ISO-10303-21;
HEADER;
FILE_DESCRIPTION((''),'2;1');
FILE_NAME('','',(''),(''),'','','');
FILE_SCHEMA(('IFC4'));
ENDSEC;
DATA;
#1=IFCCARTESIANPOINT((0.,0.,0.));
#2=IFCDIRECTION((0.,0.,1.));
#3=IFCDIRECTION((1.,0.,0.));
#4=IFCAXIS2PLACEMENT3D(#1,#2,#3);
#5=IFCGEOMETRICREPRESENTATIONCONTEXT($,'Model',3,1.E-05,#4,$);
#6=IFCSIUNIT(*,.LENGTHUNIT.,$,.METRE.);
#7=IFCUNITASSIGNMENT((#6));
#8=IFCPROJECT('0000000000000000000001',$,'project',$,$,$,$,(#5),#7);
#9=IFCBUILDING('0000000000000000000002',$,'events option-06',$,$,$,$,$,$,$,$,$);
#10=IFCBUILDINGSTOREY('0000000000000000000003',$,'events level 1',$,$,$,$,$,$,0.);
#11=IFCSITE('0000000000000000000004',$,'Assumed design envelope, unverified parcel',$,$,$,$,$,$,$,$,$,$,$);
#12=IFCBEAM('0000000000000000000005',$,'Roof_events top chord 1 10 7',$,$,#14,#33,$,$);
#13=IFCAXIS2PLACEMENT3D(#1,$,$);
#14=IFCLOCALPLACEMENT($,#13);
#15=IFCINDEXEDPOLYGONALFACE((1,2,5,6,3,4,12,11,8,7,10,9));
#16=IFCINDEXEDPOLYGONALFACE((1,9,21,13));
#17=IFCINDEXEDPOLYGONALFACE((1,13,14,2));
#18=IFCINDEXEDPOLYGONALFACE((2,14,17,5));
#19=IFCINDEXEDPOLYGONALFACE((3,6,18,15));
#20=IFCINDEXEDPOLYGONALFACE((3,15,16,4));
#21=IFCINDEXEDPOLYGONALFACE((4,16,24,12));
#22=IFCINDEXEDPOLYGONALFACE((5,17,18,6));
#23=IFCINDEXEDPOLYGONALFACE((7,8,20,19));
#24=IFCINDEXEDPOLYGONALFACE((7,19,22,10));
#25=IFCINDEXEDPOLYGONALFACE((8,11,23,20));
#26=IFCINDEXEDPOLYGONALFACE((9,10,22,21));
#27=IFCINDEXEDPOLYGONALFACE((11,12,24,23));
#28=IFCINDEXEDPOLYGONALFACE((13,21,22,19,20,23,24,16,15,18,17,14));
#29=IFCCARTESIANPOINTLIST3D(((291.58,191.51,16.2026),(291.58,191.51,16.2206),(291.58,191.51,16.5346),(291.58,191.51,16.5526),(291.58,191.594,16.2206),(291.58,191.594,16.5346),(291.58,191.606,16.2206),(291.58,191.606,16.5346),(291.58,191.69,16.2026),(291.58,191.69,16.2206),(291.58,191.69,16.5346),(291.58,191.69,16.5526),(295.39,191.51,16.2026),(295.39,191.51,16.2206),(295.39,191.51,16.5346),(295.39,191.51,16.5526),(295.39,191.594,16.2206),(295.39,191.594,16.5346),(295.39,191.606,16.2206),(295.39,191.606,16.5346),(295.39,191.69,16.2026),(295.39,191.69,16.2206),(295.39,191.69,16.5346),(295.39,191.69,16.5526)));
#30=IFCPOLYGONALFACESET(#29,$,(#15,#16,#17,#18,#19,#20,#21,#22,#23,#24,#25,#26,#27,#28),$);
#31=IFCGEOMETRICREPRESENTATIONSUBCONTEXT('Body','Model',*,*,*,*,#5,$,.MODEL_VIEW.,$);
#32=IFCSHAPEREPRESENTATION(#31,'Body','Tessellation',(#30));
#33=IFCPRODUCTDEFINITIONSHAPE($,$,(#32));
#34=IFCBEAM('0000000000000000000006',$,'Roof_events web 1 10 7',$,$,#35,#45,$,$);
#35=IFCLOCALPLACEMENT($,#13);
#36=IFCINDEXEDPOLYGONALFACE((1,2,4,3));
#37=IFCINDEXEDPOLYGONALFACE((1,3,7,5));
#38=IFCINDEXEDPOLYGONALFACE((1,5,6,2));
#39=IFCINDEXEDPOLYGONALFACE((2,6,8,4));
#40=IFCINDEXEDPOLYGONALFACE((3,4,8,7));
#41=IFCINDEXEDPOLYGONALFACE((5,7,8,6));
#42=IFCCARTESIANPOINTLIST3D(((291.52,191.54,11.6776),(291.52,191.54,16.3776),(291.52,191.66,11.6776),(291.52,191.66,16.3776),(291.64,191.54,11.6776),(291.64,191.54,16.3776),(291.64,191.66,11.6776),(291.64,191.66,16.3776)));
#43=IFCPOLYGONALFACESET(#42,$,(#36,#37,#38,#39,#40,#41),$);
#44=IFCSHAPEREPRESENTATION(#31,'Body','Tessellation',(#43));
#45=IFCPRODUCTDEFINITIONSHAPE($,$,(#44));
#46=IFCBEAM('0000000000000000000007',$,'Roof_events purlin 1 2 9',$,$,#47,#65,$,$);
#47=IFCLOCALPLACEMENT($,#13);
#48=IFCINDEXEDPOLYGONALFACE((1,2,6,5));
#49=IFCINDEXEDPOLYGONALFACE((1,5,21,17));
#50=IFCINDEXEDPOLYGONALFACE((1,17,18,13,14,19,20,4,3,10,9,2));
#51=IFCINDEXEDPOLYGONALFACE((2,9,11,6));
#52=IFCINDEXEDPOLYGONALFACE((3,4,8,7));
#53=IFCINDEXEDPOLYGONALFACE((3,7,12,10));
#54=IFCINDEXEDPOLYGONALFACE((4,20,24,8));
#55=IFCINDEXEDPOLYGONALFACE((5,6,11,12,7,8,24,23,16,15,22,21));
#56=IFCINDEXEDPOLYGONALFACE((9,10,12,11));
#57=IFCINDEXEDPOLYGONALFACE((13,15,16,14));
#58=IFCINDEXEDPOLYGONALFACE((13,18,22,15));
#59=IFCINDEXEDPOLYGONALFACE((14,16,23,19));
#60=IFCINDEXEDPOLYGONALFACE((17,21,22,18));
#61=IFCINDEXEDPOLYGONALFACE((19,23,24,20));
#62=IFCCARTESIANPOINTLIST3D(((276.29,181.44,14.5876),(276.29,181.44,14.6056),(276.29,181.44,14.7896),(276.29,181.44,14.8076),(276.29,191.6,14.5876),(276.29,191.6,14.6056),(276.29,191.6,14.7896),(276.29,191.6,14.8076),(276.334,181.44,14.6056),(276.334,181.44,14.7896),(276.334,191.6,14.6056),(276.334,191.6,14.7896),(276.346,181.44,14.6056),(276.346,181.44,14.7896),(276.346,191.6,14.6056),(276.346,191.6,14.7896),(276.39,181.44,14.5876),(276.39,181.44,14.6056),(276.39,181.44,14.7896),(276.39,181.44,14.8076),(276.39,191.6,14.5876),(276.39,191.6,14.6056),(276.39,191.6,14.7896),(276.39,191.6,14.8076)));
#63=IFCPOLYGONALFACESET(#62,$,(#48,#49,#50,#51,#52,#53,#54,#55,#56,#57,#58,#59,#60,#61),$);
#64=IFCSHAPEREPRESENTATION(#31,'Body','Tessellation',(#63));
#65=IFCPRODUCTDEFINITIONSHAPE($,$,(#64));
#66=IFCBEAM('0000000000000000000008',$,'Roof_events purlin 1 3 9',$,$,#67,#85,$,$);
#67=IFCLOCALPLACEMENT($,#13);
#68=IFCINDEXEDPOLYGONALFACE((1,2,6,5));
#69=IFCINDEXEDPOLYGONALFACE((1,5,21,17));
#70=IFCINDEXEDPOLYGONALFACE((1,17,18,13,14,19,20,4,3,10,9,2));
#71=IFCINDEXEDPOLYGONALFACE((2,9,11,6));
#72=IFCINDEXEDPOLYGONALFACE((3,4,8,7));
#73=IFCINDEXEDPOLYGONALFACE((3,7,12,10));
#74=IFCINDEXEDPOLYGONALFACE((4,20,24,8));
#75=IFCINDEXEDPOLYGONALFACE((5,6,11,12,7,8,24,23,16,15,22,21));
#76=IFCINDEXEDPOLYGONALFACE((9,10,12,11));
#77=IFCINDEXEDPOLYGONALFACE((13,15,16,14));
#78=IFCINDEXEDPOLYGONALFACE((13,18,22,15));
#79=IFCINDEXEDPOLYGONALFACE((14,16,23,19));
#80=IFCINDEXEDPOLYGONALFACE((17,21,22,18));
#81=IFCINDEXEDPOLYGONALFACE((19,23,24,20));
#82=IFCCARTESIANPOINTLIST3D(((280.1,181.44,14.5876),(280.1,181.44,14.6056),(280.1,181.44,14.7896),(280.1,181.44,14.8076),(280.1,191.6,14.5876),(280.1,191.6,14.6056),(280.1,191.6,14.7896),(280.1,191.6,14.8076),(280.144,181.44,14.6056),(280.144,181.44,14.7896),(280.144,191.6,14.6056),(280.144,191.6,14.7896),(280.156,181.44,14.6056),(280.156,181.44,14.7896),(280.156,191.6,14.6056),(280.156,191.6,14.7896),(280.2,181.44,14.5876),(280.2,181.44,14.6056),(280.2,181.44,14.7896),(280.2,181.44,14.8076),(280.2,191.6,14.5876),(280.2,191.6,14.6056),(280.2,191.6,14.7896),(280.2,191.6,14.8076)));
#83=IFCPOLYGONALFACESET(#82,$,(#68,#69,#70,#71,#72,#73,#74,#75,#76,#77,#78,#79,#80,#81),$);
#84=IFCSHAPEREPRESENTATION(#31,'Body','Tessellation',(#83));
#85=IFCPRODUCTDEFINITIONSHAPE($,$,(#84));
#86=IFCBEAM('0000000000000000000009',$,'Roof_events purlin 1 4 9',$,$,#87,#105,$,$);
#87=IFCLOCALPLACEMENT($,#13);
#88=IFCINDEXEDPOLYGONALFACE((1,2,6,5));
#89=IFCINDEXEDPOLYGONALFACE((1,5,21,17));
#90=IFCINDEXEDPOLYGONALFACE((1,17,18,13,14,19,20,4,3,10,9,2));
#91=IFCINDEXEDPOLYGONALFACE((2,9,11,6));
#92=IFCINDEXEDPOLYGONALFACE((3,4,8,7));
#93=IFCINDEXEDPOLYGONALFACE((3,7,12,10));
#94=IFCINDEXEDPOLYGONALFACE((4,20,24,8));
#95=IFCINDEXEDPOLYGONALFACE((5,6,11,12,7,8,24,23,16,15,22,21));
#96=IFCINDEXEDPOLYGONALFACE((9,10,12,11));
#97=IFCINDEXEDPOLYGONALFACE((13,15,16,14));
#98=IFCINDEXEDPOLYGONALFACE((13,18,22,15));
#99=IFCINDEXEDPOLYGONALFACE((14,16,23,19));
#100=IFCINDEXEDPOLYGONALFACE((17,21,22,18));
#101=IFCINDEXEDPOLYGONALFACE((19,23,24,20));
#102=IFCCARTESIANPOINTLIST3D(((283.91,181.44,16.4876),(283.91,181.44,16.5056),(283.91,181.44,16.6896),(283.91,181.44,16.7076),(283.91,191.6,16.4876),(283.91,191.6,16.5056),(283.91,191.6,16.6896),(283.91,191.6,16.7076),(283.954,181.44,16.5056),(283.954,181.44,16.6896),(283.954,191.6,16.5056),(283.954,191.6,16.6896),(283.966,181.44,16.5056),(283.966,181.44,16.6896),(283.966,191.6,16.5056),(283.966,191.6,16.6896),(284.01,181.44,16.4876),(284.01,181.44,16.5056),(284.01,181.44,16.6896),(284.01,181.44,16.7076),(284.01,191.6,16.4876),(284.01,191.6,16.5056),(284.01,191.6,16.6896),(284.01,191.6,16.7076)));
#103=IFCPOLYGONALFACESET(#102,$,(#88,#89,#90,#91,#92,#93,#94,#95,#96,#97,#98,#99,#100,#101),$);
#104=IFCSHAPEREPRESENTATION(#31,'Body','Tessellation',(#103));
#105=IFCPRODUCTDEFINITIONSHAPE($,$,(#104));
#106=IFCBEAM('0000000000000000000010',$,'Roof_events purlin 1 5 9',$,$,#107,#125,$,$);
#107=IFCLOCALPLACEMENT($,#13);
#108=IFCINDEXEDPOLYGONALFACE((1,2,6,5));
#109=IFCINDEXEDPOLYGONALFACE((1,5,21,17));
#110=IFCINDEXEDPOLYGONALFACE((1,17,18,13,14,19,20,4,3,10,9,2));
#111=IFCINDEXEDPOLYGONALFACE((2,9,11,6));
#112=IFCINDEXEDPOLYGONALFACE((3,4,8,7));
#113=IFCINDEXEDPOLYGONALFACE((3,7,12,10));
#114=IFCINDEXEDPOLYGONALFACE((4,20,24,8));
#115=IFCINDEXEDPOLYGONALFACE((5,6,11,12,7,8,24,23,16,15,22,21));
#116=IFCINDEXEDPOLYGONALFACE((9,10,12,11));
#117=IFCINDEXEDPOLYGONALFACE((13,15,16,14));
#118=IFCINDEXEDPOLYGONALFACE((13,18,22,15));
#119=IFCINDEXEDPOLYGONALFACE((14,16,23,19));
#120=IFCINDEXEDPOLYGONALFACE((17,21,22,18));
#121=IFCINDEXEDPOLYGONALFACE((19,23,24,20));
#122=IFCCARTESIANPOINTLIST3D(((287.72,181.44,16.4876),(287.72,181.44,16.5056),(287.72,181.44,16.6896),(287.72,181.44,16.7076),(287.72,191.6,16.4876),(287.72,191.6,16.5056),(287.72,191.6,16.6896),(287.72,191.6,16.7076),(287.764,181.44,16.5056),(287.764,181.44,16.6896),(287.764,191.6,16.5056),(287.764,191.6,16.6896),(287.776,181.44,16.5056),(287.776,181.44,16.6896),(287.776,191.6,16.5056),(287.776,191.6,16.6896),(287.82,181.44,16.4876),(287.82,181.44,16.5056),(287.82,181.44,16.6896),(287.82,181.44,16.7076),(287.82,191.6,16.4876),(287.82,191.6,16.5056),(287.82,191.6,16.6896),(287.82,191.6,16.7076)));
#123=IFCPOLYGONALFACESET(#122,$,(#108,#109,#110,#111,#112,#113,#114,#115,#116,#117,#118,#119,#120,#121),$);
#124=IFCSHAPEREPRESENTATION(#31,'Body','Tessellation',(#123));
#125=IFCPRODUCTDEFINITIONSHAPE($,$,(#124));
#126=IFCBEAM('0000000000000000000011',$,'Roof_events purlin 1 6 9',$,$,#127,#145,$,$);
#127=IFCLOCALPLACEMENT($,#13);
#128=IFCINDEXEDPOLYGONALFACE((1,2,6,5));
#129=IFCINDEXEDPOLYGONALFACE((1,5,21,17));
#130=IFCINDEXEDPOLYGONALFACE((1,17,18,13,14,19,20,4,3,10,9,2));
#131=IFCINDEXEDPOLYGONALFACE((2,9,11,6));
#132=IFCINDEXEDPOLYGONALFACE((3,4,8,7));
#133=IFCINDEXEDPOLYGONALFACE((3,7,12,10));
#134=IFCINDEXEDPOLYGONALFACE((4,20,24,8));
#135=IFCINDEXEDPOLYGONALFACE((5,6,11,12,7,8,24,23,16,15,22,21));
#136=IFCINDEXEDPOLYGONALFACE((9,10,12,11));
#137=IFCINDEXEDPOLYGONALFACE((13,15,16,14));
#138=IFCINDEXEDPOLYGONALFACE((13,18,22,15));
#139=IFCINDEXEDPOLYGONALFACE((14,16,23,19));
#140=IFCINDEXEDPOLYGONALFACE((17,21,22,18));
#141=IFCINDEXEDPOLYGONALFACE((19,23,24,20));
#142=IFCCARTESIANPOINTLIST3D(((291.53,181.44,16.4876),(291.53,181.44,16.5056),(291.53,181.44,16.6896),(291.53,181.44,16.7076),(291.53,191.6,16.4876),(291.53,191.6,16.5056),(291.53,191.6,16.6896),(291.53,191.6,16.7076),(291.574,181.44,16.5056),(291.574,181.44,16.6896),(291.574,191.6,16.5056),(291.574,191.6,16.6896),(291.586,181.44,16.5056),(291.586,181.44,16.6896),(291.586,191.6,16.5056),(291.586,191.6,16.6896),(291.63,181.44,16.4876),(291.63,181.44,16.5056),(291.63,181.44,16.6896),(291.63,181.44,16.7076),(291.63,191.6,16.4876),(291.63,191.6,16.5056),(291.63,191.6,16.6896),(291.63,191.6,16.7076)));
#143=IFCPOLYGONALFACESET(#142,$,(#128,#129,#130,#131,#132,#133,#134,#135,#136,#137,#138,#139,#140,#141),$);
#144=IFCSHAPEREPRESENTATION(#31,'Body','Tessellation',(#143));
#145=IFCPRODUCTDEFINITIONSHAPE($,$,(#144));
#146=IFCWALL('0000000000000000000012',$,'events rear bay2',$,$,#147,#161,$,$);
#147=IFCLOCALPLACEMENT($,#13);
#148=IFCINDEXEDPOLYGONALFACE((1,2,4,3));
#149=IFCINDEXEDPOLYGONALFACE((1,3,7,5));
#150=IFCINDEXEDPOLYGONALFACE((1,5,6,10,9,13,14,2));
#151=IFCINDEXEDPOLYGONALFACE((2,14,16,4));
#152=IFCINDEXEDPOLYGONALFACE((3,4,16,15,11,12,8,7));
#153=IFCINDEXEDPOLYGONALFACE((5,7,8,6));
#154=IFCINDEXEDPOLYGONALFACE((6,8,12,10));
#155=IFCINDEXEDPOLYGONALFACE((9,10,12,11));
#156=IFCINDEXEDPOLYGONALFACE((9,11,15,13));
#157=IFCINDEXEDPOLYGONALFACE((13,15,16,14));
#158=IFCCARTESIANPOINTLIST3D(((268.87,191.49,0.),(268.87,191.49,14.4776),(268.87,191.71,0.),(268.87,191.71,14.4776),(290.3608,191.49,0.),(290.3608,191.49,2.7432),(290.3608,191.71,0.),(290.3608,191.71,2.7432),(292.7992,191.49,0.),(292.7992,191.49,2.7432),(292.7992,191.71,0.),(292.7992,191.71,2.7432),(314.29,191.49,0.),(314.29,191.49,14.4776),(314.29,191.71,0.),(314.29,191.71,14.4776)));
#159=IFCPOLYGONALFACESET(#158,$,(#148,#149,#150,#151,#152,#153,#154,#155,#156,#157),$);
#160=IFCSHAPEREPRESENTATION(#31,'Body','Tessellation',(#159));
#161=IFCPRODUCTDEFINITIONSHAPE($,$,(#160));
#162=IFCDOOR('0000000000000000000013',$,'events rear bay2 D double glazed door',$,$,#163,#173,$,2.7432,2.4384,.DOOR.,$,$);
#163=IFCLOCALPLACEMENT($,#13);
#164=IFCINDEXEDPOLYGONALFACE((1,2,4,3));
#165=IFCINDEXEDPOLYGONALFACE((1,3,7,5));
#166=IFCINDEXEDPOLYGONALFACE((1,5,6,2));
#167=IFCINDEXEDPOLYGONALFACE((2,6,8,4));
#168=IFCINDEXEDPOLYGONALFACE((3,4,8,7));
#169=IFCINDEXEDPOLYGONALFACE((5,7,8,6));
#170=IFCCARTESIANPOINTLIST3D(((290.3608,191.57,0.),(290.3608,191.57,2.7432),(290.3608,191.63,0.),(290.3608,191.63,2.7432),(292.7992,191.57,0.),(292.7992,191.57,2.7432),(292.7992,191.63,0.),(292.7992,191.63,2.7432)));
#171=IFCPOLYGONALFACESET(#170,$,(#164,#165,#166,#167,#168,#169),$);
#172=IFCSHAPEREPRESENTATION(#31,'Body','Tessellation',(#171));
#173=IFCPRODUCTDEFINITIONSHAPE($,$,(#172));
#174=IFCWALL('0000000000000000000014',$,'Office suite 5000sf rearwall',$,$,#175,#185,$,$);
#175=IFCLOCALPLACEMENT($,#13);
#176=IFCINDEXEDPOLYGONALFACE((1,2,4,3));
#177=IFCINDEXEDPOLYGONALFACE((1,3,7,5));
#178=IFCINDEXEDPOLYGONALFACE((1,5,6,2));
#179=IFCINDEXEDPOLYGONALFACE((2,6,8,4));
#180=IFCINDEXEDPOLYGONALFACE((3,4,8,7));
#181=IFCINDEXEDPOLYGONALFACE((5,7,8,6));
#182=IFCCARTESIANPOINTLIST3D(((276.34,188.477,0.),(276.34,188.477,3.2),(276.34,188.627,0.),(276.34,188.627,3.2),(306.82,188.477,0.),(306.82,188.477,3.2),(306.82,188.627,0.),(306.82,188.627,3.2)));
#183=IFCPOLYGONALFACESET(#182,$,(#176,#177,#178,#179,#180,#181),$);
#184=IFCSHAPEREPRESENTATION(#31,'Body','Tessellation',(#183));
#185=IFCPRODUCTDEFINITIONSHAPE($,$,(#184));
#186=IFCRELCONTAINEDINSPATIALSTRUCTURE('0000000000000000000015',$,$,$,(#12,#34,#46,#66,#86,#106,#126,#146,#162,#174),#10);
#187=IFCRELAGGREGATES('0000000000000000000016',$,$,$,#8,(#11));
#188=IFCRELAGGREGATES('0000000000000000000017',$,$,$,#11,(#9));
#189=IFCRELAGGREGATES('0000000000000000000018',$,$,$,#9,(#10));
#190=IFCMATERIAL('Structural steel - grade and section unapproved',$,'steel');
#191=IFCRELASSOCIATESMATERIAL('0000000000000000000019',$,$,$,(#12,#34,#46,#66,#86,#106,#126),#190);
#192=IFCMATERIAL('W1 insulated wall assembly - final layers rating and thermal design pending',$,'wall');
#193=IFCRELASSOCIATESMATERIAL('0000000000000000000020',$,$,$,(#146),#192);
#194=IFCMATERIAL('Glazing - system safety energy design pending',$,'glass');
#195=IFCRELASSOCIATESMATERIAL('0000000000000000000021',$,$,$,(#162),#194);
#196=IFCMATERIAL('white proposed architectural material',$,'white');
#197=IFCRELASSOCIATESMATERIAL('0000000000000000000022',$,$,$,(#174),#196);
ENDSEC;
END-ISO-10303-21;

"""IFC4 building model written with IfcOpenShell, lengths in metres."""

from ifc_helpers import new_model, si_unit, frame, origin_with_axes, place, context, subcontext, project, spatial, rectangle, i_section, extrude, material, element, fill, save


model = new_model("IFC4")

# Units and contexts
model_context = context("Model", 3, precision=1e-05, world=origin_with_axes())
body_context = subcontext(model_context, "Body", "Model", "MODEL_VIEW")
ifc_project = project(units=[si_unit("LENGTHUNIT", "METRE")], contexts=[model_context])

# Site, building, storey
site = spatial("IfcSite", under=ifc_project, Name="Assumed design envelope, unverified parcel")
building = spatial("IfcBuilding", under=site, Name="events option-06")
storey = spatial("IfcBuildingStorey", under=building, Name="events level 1", Elevation=0.0)

# Beams
ifc_material_1 = material(Name="Structural steel - grade and section unapproved", Category="steel")
beam_1_placement = place(None, frame((291.58, 191.6, 16.3776), z_axis=(1.0, 0.0, 0.0), x_axis=(0.0, 1.0, 0.0)))
element("IfcBeam", 1, at=beam_1_placement, inside=storey, material=ifc_material_1, Name="Roof_events top chord 1 10 7", context=body_context, shape_type="SweptSolid", body=[
    extrude(i_section(OverallWidth=0.18, OverallDepth=0.35, WebThickness=0.012, FlangeThickness=0.018, FilletRadius=0.0), origin_with_axes(), (0.0, 0.0, 1.0), 3.81),
])
beam_2_placement = place(None, frame((291.58, 191.6, 11.6776), z_axis=(0.0, 0.0, 1.0), x_axis=(-1.0, 0.0, 0.0)))
element("IfcBeam", 2, at=beam_2_placement, inside=storey, material=ifc_material_1, Name="Roof_events web 1 10 7", context=body_context, shape_type="SweptSolid", body=[
    extrude(rectangle(XDim=0.12, YDim=0.12), origin_with_axes(), (0.0, 0.0, 1.0), 4.7),
])
for number, where, z_axis, x_axis, name in (
    (3, (276.34, 181.44, 14.6976), (0.0, 1.0, 0.0), (-1.0, 0.0, 0.0), "Roof_events purlin 1 2 9"),
    (4, (280.15, 181.44, 14.6976), (0.0, 1.0, 0.0), (-1.0, 0.0, 0.0), "Roof_events purlin 1 3 9"),
    (5, (283.96, 181.44, 16.5976), (0.0, 1.0, 0.0), (-1.0, 0.0, 0.0), "Roof_events purlin 1 4 9"),
    (6, (287.77, 181.44, 16.5976), (0.0, 1.0, 0.0), (-1.0, 0.0, 0.0), "Roof_events purlin 1 5 9"),
    (7, (291.58, 181.44, 16.5976), (0.0, 1.0, 0.0), (-1.0, 0.0, 0.0), "Roof_events purlin 1 6 9"),
):
    element("IfcBeam", number, at=place(None, frame(where, z_axis=z_axis, x_axis=x_axis)), inside=storey, material=ifc_material_1, Name=name, context=body_context, shape_type="SweptSolid", body=[
        extrude(i_section(OverallWidth=0.1, OverallDepth=0.22, WebThickness=0.012, FlangeThickness=0.018, FilletRadius=0.0), origin_with_axes(), (0.0, 0.0, 1.0), 10.16),
    ])

# Wall, opening, door
ifc_material_2 = material(Name="W1 insulated wall assembly - final layers rating and thermal design pending", Category="wall")
wall_1_placement = place(None, frame((291.58, 191.6, 0.0), z_axis=(0.0, 0.0, 1.0), x_axis=(1.0, 0.0, 0.0)))
wall_1 = element("IfcWall", 8, at=wall_1_placement, inside=storey, material=ifc_material_2, Name="events rear bay2", context=body_context, shape_type="SweptSolid", body=[
    extrude(rectangle(XDim=45.42, YDim=0.22), origin_with_axes(), (0.0, 0.0, 1.0), 14.4776),
])
opening_placement = place(None, frame((291.58, 191.6, 0.0), z_axis=(0.0, 0.0, 1.0), x_axis=(1.0, 0.0, 0.0)))
opening = element("IfcOpeningElement", 9, at=opening_placement, cuts=wall_1, context=body_context, shape_type="SweptSolid", body=[
    extrude(rectangle(XDim=2.4384, YDim=0.32), origin_with_axes(), (0.0, 0.0, 1.0), 2.7432),
])
ifc_material_3 = material(Name="Glazing - system safety energy design pending", Category="glass")
door_placement = place(None, frame((291.58, 191.6, 0.0), z_axis=(0.0, 0.0, 1.0), x_axis=(1.0, 0.0, 0.0)))
door = element("IfcDoor", 10, at=door_placement, inside=storey, material=ifc_material_3, Name="events rear bay2 D double glazed door", OverallHeight=2.7432, OverallWidth=2.4384, PredefinedType="DOOR", context=body_context, shape_type="SweptSolid", body=[
    extrude(rectangle(XDim=2.4384, YDim=0.06), origin_with_axes(), (0.0, 0.0, 1.0), 2.7432),
])
fill(opening, door)

# Wall
ifc_material_4 = material(Name="white proposed architectural material", Category="white")
wall_2_placement = place(None, frame((291.58, 188.552, 0.0), z_axis=(0.0, 0.0, 1.0), x_axis=(1.0, 0.0, 0.0)))
element("IfcWall", 11, at=wall_2_placement, inside=storey, material=ifc_material_4, Name="Office suite 5000sf rearwall", context=body_context, shape_type="SweptSolid", body=[
    extrude(rectangle(XDim=30.48, YDim=0.15), origin_with_axes(), (0.0, 0.0, 1.0), 3.2),
])

save(model, "model.ifc")
